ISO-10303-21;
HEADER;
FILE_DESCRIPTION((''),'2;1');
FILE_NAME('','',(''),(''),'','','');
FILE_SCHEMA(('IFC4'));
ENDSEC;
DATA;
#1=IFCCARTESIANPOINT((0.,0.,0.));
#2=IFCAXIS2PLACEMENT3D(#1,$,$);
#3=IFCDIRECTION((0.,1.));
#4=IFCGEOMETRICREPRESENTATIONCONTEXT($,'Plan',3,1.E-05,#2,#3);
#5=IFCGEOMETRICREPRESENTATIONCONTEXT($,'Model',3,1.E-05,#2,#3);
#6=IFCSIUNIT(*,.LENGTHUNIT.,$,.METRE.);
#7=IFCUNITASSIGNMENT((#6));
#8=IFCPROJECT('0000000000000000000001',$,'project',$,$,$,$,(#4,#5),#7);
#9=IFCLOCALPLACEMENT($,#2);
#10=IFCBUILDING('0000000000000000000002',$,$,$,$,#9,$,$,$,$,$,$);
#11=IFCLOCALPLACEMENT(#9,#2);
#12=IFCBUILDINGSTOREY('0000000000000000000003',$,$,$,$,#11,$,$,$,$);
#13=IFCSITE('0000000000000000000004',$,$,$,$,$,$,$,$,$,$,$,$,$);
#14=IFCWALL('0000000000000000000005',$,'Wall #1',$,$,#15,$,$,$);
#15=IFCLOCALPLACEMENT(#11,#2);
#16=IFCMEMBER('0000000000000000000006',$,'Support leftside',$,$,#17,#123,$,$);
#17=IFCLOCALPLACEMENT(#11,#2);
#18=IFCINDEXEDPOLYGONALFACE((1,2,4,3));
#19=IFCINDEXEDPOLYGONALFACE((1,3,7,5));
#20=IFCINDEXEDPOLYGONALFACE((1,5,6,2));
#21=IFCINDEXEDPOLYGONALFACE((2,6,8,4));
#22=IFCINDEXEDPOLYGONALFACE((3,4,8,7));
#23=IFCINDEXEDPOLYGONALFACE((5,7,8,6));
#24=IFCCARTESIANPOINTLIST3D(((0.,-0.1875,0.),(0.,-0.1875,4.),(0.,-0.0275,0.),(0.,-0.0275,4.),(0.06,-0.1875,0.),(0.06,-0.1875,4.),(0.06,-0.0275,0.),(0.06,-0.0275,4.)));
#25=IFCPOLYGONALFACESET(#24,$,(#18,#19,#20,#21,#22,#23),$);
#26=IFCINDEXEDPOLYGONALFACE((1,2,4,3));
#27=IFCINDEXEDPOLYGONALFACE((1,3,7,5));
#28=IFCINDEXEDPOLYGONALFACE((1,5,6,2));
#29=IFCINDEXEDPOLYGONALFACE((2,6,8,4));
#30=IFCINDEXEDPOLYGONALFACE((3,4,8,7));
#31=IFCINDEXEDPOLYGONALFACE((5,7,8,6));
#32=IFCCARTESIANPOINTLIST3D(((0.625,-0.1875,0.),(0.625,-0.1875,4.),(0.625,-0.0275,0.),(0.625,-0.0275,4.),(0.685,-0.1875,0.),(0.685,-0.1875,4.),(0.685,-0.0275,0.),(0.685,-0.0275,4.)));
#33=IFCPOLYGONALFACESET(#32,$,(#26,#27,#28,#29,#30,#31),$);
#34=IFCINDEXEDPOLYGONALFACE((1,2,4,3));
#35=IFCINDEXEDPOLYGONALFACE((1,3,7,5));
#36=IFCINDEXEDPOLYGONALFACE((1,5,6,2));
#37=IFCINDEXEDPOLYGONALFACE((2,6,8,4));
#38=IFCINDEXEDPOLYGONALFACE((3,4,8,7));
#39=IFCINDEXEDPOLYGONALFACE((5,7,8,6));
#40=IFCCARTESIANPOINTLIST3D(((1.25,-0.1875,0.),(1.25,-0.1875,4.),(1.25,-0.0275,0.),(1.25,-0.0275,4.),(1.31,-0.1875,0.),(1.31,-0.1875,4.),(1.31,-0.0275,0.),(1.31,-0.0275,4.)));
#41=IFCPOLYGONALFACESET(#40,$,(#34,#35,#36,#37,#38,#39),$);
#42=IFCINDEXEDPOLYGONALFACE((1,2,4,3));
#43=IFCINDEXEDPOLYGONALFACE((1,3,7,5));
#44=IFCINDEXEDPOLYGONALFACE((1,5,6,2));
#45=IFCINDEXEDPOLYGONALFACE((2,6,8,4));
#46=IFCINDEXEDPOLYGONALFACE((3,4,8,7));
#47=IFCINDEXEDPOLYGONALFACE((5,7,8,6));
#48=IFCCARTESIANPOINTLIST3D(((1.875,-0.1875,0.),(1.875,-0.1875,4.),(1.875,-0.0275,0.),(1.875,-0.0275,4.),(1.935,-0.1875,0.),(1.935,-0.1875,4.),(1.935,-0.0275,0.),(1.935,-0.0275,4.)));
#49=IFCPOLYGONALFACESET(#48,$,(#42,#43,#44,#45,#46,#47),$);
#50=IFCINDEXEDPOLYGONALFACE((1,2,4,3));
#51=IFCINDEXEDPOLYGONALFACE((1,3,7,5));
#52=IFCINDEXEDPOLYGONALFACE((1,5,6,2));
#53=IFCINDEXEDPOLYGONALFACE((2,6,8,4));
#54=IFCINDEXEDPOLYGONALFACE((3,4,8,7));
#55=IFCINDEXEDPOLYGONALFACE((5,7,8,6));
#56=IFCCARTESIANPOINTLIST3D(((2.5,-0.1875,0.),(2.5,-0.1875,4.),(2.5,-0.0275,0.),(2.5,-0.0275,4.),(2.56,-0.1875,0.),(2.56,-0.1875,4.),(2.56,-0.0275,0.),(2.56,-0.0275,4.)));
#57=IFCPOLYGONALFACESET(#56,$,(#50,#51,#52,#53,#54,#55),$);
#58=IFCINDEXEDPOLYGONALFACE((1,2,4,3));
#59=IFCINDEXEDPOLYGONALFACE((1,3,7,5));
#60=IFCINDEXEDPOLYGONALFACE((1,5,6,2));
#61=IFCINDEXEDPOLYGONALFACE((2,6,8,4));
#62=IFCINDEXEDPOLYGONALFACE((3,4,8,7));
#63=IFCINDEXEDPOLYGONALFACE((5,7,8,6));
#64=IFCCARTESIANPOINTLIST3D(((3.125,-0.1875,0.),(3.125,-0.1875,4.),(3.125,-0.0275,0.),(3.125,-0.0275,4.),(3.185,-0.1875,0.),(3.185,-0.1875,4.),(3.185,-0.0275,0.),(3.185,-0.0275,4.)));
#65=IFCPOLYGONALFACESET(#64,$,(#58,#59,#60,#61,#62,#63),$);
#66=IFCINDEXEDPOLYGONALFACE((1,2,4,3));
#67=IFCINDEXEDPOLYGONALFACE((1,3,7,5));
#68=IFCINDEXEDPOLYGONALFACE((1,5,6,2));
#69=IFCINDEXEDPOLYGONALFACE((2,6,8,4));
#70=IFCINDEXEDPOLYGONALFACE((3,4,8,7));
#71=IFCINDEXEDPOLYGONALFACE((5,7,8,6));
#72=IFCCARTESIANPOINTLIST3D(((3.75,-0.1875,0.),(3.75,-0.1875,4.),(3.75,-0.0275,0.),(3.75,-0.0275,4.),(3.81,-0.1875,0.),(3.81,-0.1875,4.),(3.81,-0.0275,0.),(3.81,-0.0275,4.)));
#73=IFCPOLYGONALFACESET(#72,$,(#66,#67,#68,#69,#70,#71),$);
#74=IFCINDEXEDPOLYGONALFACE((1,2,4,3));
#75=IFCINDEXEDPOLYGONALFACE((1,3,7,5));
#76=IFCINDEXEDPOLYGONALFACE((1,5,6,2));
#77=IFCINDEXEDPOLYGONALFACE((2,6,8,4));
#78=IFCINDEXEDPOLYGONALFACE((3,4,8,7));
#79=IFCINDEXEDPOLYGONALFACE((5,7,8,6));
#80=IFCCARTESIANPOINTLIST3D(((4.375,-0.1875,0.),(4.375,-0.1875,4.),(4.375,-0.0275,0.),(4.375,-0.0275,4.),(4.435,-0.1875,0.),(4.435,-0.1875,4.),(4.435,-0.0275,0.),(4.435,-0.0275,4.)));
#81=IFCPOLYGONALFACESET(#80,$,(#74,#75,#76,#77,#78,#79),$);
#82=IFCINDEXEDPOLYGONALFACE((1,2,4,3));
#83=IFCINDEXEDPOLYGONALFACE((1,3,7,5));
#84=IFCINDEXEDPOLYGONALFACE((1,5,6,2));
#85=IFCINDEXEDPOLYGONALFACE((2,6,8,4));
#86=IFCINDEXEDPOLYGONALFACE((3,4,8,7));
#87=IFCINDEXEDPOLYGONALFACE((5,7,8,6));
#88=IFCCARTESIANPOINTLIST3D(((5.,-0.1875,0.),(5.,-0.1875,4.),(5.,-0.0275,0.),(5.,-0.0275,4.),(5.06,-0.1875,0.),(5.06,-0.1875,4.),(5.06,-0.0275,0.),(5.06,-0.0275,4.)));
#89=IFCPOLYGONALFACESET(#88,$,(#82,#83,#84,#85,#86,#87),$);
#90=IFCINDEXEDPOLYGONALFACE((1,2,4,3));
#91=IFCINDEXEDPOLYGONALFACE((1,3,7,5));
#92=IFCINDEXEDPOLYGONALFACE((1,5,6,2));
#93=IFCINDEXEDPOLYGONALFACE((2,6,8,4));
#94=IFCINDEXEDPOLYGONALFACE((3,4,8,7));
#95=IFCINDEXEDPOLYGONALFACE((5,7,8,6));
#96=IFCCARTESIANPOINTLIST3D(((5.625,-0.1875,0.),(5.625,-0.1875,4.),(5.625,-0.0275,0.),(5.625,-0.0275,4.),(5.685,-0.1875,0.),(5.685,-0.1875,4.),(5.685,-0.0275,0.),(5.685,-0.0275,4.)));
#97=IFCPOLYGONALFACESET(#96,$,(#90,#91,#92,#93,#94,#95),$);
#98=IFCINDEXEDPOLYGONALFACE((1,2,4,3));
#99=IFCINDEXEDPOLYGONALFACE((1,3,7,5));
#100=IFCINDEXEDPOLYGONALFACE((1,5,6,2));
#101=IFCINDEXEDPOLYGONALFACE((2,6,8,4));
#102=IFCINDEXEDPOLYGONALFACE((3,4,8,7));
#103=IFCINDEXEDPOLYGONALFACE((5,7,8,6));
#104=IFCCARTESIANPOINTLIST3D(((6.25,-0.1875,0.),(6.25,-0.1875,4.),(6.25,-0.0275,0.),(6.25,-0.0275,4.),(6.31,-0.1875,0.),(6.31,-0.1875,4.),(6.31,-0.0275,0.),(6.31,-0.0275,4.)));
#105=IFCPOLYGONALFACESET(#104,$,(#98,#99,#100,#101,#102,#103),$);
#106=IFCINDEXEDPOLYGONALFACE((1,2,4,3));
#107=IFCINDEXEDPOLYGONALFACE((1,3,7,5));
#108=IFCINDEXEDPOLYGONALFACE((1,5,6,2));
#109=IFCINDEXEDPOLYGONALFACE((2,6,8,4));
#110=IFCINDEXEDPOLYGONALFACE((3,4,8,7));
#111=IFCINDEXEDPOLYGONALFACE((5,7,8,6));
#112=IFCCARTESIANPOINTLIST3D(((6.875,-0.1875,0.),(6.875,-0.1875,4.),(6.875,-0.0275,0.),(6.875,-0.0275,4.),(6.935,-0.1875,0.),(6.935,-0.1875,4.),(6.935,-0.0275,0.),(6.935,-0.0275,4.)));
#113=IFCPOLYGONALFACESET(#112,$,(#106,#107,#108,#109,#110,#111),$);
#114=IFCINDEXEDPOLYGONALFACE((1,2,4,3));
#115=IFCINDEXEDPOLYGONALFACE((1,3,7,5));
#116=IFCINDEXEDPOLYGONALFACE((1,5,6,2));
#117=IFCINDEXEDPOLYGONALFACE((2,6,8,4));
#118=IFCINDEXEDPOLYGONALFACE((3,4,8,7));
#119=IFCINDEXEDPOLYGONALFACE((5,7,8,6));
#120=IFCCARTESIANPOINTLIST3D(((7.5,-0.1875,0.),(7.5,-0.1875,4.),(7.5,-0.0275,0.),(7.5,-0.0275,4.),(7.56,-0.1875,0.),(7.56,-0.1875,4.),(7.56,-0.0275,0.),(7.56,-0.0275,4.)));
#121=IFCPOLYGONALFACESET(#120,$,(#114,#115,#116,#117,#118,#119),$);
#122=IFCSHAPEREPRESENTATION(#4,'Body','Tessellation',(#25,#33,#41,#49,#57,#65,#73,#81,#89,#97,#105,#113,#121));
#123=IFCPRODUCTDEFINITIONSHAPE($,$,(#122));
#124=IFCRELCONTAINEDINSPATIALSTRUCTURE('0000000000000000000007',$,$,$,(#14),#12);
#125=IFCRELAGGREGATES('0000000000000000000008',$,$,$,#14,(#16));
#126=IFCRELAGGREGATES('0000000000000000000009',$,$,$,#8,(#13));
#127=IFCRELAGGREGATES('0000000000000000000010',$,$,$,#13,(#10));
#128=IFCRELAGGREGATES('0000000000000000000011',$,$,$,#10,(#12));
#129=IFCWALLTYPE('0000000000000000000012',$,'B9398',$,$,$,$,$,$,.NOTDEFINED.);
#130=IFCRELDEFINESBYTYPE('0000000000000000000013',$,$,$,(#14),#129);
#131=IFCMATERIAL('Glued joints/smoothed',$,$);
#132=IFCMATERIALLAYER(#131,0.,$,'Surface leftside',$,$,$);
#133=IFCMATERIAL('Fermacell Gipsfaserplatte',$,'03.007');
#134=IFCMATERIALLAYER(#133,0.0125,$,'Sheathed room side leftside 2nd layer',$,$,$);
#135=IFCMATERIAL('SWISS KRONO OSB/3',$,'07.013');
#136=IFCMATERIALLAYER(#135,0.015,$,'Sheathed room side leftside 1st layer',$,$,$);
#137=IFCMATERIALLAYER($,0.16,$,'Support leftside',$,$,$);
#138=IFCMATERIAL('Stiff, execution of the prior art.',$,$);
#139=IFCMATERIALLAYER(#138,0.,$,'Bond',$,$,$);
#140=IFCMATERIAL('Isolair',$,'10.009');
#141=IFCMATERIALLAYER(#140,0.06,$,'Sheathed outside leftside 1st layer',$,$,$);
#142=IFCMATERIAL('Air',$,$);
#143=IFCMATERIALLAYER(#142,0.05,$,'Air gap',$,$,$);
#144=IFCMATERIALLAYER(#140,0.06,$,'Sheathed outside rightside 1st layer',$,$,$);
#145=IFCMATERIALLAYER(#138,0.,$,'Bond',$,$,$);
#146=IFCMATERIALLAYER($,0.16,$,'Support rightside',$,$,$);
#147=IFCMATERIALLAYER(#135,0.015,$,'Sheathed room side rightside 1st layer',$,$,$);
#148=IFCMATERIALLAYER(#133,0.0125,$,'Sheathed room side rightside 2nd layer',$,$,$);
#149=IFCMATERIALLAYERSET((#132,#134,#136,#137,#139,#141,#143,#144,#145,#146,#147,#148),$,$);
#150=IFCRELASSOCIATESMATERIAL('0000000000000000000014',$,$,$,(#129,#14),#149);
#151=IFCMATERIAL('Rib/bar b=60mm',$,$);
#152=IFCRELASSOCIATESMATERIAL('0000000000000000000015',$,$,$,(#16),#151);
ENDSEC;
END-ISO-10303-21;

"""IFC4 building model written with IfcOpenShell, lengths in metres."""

from ifc_helpers import new_model, si_unit, direction, frame, frame_2d, origin, place, context, project, spatial, rectangle, extrude, material, layer, layer_set, type_object, element, aggregate, save


model = new_model("IFC4")

# Units and contexts
plan_context = context("Plan", 3, precision=1e-05, world=origin(), true_north=direction((0.0, 1.0)))
model_context = context("Model", 3, precision=1e-05, world=origin(), true_north=direction((0.0, 1.0)))
ifc_project = project(units=[si_unit("LENGTHUNIT", "METRE")], contexts=[plan_context, model_context])

# Site, building, storey
site = spatial("IfcSite", under=ifc_project)
building_placement = place(None, origin())
building = spatial("IfcBuilding", under=site, at=building_placement)
storey_placement = place(building_placement, origin())
storey = spatial("IfcBuildingStorey", under=building, at=storey_placement)

# Wall, member
ifc_material_1 = material(Name="Glued joints/smoothed")
ifc_layer_1 = layer(ifc_material_1, 0.0, Name="Surface leftside")
ifc_material_2 = material(Name="Fermacell Gipsfaserplatte", Category="03.007")
ifc_layer_2 = layer(ifc_material_2, 0.0125, Name="Sheathed room side leftside 2nd layer")
ifc_material_3 = material(Name="SWISS KRONO OSB/3", Category="07.013")
ifc_layer_3 = layer(ifc_material_3, 0.015, Name="Sheathed room side leftside 1st layer")
ifc_layer_4 = layer(None, 0.16, Name="Support leftside")
ifc_material_4 = material(Name="Stiff, execution of the prior art.")
ifc_layer_5 = layer(ifc_material_4, 0.0, Name="Bond")
ifc_material_5 = material(Name="Isolair", Category="10.009")
ifc_layer_6 = layer(ifc_material_5, 0.06, Name="Sheathed outside leftside 1st layer")
ifc_material_6 = material(Name="Air")
ifc_layer_7 = layer(ifc_material_6, 0.05, Name="Air gap")
ifc_layer_8 = layer(ifc_material_5, 0.06, Name="Sheathed outside rightside 1st layer")
ifc_layer_9 = layer(ifc_material_4, 0.0, Name="Bond")
ifc_layer_10 = layer(None, 0.16, Name="Support rightside")
ifc_layer_11 = layer(ifc_material_3, 0.015, Name="Sheathed room side rightside 1st layer")
ifc_layer_12 = layer(ifc_material_2, 0.0125, Name="Sheathed room side rightside 2nd layer")
ifc_layer_set = layer_set([ifc_layer_1, ifc_layer_2, ifc_layer_3, ifc_layer_4, ifc_layer_5, ifc_layer_6, ifc_layer_7, ifc_layer_8, ifc_layer_9, ifc_layer_10, ifc_layer_11, ifc_layer_12])
wall_type = type_object("IfcWallType", Name="B9398", PredefinedType="NOTDEFINED", material=ifc_layer_set)
wall_placement = place(None, frame((0.0, 0.0, 0.0), z_axis=(0.0, -1.0, 0.0), x_axis=(1.0, 0.0, 0.0)))
wall = element("IfcWall", 1, at=wall_placement, inside=storey, type_object=wall_type, material=ifc_layer_set, Name="Wall #1")
ifc_material_7 = material(Name="Rib/bar b=60mm")
member_1_placement = place(wall_placement, origin())
member_1 = element("IfcMember", 2, at=member_1_placement, material=ifc_material_7, Name="Support leftside", context=plan_context, shape_type="SweptSolid", body=[
    extrude(rectangle(XDim=0.06, YDim=0.16, at=frame_2d((0.03, 0.08), x_axis=(1.0, 0.0))), frame((0.0, 4.0, 0.0275), z_axis=(0.0, -1.0, 0.0), x_axis=(1.0, 0.0, 0.0)), (0.0, 0.0, 1.0), 4.0),
    extrude(rectangle(XDim=0.06, YDim=0.16, at=frame_2d((0.03, 0.08), x_axis=(1.0, 0.0))), frame((0.625, 4.0, 0.0275), z_axis=(0.0, -1.0, 0.0), x_axis=(1.0, 0.0, 0.0)), (0.0, 0.0, 1.0), 4.0),
    extrude(rectangle(XDim=0.06, YDim=0.16, at=frame_2d((0.03, 0.08), x_axis=(1.0, 0.0))), frame((1.25, 4.0, 0.0275), z_axis=(0.0, -1.0, 0.0), x_axis=(1.0, 0.0, 0.0)), (0.0, 0.0, 1.0), 4.0),
    extrude(rectangle(XDim=0.06, YDim=0.16, at=frame_2d((0.03, 0.08), x_axis=(1.0, 0.0))), frame((1.875, 4.0, 0.0275), z_axis=(0.0, -1.0, 0.0), x_axis=(1.0, 0.0, 0.0)), (0.0, 0.0, 1.0), 4.0),
    extrude(rectangle(XDim=0.06, YDim=0.16, at=frame_2d((0.03, 0.08), x_axis=(1.0, 0.0))), frame((2.5, 4.0, 0.0275), z_axis=(0.0, -1.0, 0.0), x_axis=(1.0, 0.0, 0.0)), (0.0, 0.0, 1.0), 4.0),
    extrude(rectangle(XDim=0.06, YDim=0.16, at=frame_2d((0.03, 0.08), x_axis=(1.0, 0.0))), frame((3.125, 4.0, 0.0275), z_axis=(0.0, -1.0, 0.0), x_axis=(1.0, 0.0, 0.0)), (0.0, 0.0, 1.0), 4.0),
    extrude(rectangle(XDim=0.06, YDim=0.16, at=frame_2d((0.03, 0.08), x_axis=(1.0, 0.0))), frame((3.75, 4.0, 0.0275), z_axis=(0.0, -1.0, 0.0), x_axis=(1.0, 0.0, 0.0)), (0.0, 0.0, 1.0), 4.0),
    extrude(rectangle(XDim=0.06, YDim=0.16, at=frame_2d((0.03, 0.08), x_axis=(1.0, 0.0))), frame((4.375, 4.0, 0.0275), z_axis=(0.0, -1.0, 0.0), x_axis=(1.0, 0.0, 0.0)), (0.0, 0.0, 1.0), 4.0),
    extrude(rectangle(XDim=0.06, YDim=0.16, at=frame_2d((0.03, 0.08), x_axis=(1.0, 0.0))), frame((5.0, 4.0, 0.0275), z_axis=(0.0, -1.0, 0.0), x_axis=(1.0, 0.0, 0.0)), (0.0, 0.0, 1.0), 4.0),
    extrude(rectangle(XDim=0.06, YDim=0.16, at=frame_2d((0.03, 0.08), x_axis=(1.0, 0.0))), frame((5.625, 4.0, 0.0275), z_axis=(0.0, -1.0, 0.0), x_axis=(1.0, 0.0, 0.0)), (0.0, 0.0, 1.0), 4.0),
    extrude(rectangle(XDim=0.06, YDim=0.16, at=frame_2d((0.03, 0.08), x_axis=(1.0, 0.0))), frame((6.25, 4.0, 0.0275), z_axis=(0.0, -1.0, 0.0), x_axis=(1.0, 0.0, 0.0)), (0.0, 0.0, 1.0), 4.0),
    extrude(rectangle(XDim=0.06, YDim=0.16, at=frame_2d((0.03, 0.08), x_axis=(1.0, 0.0))), frame((6.875, 4.0, 0.0275), z_axis=(0.0, -1.0, 0.0), x_axis=(1.0, 0.0, 0.0)), (0.0, 0.0, 1.0), 4.0),
    extrude(rectangle(XDim=0.06, YDim=0.16, at=frame_2d((0.03, 0.08), x_axis=(1.0, 0.0))), frame((7.5, 4.0, 0.0275), z_axis=(0.0, -1.0, 0.0), x_axis=(1.0, 0.0, 0.0)), (0.0, 0.0, 1.0), 4.0),
])
aggregate(wall, [member_1])

save(model, "model.ifc")
